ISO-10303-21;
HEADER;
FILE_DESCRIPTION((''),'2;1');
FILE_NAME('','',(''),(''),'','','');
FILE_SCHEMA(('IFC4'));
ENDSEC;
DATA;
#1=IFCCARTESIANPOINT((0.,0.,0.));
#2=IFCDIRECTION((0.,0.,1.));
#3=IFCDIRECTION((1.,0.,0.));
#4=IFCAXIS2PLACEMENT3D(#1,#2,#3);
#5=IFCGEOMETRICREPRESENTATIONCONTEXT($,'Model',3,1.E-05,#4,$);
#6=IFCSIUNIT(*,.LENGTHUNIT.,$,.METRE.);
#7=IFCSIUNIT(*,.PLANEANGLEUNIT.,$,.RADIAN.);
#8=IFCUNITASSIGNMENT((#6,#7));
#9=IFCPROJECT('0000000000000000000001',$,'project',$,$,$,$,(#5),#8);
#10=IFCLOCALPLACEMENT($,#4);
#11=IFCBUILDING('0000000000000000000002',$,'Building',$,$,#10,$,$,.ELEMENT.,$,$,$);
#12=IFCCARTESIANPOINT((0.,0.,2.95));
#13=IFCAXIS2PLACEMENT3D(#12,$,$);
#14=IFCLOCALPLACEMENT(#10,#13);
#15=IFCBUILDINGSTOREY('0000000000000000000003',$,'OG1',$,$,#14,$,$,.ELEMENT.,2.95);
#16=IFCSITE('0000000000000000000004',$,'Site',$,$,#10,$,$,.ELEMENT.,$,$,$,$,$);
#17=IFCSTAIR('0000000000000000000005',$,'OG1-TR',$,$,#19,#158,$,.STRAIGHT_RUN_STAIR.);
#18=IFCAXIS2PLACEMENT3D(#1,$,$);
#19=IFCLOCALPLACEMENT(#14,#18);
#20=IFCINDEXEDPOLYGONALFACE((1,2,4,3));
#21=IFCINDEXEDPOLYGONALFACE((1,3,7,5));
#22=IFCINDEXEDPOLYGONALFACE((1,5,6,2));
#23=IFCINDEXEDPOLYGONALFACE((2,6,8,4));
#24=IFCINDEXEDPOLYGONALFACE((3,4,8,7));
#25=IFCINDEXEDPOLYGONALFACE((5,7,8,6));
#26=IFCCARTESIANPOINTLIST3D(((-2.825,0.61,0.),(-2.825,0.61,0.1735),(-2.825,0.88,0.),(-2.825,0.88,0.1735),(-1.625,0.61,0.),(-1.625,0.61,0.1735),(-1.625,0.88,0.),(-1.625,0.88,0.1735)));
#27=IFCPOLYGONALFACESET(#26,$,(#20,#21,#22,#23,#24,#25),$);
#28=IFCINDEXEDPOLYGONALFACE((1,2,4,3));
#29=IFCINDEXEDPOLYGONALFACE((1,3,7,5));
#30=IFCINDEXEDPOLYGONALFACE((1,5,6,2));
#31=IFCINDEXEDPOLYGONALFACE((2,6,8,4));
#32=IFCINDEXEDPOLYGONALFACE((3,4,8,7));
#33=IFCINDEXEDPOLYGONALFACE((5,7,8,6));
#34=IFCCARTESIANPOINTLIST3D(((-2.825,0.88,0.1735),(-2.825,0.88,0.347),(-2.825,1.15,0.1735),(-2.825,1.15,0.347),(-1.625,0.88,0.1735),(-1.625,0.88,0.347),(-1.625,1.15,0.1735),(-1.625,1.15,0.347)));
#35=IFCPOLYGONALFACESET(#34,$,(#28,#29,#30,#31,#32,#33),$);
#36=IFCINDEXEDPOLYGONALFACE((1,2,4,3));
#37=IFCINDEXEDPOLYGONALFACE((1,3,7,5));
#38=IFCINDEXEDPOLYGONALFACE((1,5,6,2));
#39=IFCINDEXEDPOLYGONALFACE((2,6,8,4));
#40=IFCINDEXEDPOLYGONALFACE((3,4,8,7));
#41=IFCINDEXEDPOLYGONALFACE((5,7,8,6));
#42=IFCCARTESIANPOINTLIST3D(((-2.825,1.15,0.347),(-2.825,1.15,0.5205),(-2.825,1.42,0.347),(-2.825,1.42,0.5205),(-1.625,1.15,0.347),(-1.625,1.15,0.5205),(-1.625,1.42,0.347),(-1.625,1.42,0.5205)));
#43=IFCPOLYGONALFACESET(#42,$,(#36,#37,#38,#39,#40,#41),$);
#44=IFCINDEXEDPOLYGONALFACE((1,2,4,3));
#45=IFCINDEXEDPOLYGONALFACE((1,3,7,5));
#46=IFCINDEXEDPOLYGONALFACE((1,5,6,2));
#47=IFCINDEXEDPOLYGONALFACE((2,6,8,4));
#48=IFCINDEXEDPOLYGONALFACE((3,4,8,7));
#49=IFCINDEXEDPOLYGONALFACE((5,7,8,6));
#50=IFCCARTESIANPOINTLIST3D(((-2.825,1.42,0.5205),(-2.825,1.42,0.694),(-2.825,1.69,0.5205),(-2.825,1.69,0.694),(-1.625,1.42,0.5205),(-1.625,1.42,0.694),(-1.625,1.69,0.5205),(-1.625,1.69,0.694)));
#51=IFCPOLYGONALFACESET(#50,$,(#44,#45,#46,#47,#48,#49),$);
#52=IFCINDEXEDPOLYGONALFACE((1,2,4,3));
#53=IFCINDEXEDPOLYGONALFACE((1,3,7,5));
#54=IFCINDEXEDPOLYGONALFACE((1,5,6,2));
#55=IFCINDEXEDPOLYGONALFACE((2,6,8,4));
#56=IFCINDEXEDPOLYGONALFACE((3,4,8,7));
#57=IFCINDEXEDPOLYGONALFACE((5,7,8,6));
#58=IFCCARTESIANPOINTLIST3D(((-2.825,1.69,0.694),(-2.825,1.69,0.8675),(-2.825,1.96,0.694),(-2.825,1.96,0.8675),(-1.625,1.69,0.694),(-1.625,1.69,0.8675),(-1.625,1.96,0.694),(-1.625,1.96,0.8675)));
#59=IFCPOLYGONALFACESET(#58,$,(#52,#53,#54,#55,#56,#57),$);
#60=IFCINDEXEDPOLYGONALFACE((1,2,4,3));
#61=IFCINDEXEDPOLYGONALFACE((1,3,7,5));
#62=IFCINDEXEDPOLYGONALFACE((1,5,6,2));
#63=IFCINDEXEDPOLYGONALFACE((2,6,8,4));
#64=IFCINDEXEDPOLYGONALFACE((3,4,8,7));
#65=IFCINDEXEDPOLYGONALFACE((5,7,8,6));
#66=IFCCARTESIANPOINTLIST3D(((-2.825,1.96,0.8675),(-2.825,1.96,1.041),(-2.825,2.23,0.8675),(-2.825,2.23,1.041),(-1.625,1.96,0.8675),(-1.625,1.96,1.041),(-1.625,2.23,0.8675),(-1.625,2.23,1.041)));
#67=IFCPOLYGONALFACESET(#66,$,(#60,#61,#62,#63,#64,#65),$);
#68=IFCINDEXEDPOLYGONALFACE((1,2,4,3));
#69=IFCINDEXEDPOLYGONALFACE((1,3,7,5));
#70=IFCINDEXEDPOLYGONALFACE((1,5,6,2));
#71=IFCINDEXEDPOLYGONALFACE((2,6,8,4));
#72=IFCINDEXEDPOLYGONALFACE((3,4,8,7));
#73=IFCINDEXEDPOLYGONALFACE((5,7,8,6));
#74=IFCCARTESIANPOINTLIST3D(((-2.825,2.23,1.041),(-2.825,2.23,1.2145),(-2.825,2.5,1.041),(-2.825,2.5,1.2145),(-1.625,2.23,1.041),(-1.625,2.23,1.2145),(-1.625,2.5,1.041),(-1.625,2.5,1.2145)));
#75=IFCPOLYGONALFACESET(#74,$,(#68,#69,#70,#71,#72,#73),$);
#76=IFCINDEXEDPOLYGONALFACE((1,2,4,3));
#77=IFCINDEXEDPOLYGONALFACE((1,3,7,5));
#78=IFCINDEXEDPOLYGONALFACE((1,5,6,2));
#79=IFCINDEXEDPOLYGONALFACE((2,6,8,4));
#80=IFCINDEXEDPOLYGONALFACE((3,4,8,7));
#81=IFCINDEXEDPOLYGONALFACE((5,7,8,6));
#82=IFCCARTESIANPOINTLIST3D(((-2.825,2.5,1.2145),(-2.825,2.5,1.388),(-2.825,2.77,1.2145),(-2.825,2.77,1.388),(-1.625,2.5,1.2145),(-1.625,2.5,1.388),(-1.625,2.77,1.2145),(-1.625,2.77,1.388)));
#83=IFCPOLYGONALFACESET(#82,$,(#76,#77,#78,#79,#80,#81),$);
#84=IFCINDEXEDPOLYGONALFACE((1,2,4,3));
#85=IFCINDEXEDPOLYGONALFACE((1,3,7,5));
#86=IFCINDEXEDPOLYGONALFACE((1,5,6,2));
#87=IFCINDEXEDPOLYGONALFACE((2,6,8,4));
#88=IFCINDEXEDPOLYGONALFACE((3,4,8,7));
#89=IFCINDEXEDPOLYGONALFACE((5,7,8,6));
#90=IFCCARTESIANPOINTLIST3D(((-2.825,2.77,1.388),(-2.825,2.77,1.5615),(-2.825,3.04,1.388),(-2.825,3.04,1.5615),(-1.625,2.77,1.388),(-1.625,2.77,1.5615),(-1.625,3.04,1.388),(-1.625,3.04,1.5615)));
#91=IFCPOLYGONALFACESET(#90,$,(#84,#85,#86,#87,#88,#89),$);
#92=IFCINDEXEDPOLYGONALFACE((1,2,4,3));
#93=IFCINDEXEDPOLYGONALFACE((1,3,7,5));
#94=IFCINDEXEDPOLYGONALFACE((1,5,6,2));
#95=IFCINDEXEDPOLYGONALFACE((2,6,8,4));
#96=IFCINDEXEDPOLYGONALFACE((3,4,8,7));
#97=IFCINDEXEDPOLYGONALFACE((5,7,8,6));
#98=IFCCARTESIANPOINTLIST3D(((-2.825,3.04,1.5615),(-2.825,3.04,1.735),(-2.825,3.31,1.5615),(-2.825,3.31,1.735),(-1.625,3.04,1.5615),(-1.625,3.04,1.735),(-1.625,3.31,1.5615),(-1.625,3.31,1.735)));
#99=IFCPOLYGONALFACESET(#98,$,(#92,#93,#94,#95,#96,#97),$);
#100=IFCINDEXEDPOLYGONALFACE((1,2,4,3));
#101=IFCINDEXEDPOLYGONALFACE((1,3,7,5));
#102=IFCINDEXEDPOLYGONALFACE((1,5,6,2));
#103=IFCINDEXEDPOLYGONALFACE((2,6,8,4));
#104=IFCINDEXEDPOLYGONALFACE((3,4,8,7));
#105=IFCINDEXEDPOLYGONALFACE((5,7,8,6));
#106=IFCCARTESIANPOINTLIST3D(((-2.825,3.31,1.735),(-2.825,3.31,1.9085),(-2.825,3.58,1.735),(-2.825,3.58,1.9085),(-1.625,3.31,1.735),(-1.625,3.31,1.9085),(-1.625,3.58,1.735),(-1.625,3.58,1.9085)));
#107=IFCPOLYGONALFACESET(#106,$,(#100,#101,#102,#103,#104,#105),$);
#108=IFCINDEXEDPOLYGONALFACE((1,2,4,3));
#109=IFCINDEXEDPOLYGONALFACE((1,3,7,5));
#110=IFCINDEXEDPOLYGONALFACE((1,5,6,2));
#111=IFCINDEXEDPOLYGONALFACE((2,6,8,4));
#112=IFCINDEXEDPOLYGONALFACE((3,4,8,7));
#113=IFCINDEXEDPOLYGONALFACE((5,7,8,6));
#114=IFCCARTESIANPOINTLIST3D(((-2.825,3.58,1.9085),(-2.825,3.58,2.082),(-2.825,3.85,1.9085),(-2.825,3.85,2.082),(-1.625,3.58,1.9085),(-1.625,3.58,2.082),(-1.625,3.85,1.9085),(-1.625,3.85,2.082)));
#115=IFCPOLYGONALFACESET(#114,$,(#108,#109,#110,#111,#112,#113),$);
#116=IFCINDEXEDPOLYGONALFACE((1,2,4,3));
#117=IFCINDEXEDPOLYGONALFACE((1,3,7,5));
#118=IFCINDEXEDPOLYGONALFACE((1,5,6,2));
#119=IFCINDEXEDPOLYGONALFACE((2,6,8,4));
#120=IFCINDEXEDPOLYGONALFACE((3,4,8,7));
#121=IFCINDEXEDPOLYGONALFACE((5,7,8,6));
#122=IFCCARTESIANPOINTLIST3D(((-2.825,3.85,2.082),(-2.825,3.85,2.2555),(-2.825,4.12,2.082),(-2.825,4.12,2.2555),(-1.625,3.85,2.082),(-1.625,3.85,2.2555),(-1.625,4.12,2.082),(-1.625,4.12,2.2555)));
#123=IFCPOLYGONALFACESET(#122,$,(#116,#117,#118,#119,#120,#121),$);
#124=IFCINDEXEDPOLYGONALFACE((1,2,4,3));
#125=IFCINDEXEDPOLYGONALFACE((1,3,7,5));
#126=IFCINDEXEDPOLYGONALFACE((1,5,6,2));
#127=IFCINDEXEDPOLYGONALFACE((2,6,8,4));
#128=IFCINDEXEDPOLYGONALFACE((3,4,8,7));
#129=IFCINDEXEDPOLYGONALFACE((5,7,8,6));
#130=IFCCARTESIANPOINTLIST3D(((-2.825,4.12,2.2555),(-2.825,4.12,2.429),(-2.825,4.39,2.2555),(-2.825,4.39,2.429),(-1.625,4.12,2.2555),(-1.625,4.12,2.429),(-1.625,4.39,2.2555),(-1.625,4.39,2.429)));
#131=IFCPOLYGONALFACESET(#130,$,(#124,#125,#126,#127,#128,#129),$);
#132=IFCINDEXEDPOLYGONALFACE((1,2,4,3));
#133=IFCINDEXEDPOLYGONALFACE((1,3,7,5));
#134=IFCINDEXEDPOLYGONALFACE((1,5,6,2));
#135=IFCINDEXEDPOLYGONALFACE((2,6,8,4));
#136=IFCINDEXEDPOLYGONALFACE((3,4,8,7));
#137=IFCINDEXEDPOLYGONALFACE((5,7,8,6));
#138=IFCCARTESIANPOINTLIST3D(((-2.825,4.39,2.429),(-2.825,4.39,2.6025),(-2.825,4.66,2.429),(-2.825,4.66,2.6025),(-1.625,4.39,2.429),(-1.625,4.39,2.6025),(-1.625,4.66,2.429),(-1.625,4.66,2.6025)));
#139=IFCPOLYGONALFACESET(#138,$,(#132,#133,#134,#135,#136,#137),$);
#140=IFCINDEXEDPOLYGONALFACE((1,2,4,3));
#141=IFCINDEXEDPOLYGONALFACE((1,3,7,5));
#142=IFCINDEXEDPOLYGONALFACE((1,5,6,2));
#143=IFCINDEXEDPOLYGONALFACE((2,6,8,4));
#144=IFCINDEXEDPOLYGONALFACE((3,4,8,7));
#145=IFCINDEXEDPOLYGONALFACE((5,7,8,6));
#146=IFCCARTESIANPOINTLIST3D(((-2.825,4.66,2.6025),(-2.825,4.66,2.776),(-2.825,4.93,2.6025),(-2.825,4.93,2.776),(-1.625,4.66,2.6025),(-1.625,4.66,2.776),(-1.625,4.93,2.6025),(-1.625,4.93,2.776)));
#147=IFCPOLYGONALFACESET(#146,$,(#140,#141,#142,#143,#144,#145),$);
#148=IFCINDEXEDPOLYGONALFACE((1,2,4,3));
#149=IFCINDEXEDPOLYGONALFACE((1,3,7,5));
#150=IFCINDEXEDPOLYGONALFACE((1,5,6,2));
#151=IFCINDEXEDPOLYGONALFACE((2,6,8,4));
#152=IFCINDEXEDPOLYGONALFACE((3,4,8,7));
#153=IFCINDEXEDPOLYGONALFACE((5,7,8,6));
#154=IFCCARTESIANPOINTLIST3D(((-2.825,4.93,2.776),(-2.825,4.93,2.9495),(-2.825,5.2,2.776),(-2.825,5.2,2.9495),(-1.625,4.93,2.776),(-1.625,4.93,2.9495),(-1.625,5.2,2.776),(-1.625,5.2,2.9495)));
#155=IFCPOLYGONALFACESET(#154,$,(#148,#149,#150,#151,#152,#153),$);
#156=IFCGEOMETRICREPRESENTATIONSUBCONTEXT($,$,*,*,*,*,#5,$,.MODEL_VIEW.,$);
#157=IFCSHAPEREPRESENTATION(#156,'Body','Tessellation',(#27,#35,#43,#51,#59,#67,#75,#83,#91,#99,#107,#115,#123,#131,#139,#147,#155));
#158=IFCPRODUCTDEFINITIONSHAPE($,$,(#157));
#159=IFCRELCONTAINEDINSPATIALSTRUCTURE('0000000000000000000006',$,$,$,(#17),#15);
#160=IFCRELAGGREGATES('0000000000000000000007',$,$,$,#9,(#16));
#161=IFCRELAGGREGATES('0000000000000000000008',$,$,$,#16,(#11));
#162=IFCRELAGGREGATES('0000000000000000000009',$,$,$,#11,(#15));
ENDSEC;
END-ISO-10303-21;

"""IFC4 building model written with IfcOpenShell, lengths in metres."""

from ifc_helpers import new_model, si_unit, frame, frame_2d, origin, origin_with_axes, place, context, subcontext, project, spatial, rectangle, extrude, element, save


model = new_model("IFC4")

# Units and contexts
model_context = context("Model", 3, precision=1e-05, world=origin_with_axes())
sub_context = subcontext(model_context, None, None, "MODEL_VIEW")
ifc_project = project(units=[si_unit("LENGTHUNIT", "METRE"), si_unit("PLANEANGLEUNIT", "RADIAN")], contexts=[model_context])

# Site, building, storey
placement = place(None, origin_with_axes())
site = spatial("IfcSite", under=ifc_project, at=placement, Name="Site", CompositionType="ELEMENT")
building = spatial("IfcBuilding", under=site, at=placement, Name="Building", CompositionType="ELEMENT")
storey_placement = place(placement, frame((0.0, 0.0, 2.95)))
storey = spatial("IfcBuildingStorey", under=building, at=storey_placement, Name="OG1", CompositionType="ELEMENT", Elevation=2.95)

# Stair
stair_placement = place(storey_placement, frame((-1.625, 0.61, 0.0), z_axis=(0.0, 0.0, 1.0), x_axis=(0.0, 1.0, 0.0)))
element("IfcStair", 1, at=stair_placement, inside=storey, Name="OG1-TR", PredefinedType="STRAIGHT_RUN_STAIR", context=sub_context, shape_type="SolidModel", body=[
    extrude(rectangle(XDim=0.27, YDim=1.2, at=frame_2d((0.135, 0.6))), origin(), (0.0, 0.0, 1.0), 0.1735),
    extrude(rectangle(XDim=0.27, YDim=1.2, at=frame_2d((0.135, 0.6))), frame((0.27, 0.0, 0.1735)), (0.0, 0.0, 1.0), 0.1735),
    extrude(rectangle(XDim=0.27, YDim=1.2, at=frame_2d((0.135, 0.6))), frame((0.54, 0.0, 0.347)), (0.0, 0.0, 1.0), 0.1735),
    extrude(rectangle(XDim=0.27, YDim=1.2, at=frame_2d((0.135, 0.6))), frame((0.81, 0.0, 0.5205)), (0.0, 0.0, 1.0), 0.1735),
    extrude(rectangle(XDim=0.27, YDim=1.2, at=frame_2d((0.135, 0.6))), frame((1.08, 0.0, 0.694)), (0.0, 0.0, 1.0), 0.1735),
    extrude(rectangle(XDim=0.27, YDim=1.2, at=frame_2d((0.135, 0.6))), frame((1.35, 0.0, 0.8675)), (0.0, 0.0, 1.0), 0.1735),
    extrude(rectangle(XDim=0.27, YDim=1.2, at=frame_2d((0.135, 0.6))), frame((1.62, 0.0, 1.041)), (0.0, 0.0, 1.0), 0.1735),
    extrude(rectangle(XDim=0.27, YDim=1.2, at=frame_2d((0.135, 0.6))), frame((1.89, 0.0, 1.2145)), (0.0, 0.0, 1.0), 0.1735),
    extrude(rectangle(XDim=0.27, YDim=1.2, at=frame_2d((0.135, 0.6))), frame((2.16, 0.0, 1.388)), (0.0, 0.0, 1.0), 0.1735),
    extrude(rectangle(XDim=0.27, YDim=1.2, at=frame_2d((0.135, 0.6))), frame((2.43, 0.0, 1.5615)), (0.0, 0.0, 1.0), 0.1735),
    extrude(rectangle(XDim=0.27, YDim=1.2, at=frame_2d((0.135, 0.6))), frame((2.7, 0.0, 1.735)), (0.0, 0.0, 1.0), 0.1735),
    extrude(rectangle(XDim=0.27, YDim=1.2, at=frame_2d((0.135, 0.6))), frame((2.97, 0.0, 1.9085)), (0.0, 0.0, 1.0), 0.1735),
    extrude(rectangle(XDim=0.27, YDim=1.2, at=frame_2d((0.135, 0.6))), frame((3.24, 0.0, 2.082)), (0.0, 0.0, 1.0), 0.1735),
    extrude(rectangle(XDim=0.27, YDim=1.2, at=frame_2d((0.135, 0.6))), frame((3.51, 0.0, 2.2555)), (0.0, 0.0, 1.0), 0.1735),
    extrude(rectangle(XDim=0.27, YDim=1.2, at=frame_2d((0.135, 0.6))), frame((3.78, 0.0, 2.429)), (0.0, 0.0, 1.0), 0.1735),
    extrude(rectangle(XDim=0.27, YDim=1.2, at=frame_2d((0.135, 0.6))), frame((4.05, 0.0, 2.6025)), (0.0, 0.0, 1.0), 0.1735),
    extrude(rectangle(XDim=0.27, YDim=1.2, at=frame_2d((0.135, 0.6))), frame((4.32, 0.0, 2.776)), (0.0, 0.0, 1.0), 0.1735),
])

save(model, "model.ifc")
